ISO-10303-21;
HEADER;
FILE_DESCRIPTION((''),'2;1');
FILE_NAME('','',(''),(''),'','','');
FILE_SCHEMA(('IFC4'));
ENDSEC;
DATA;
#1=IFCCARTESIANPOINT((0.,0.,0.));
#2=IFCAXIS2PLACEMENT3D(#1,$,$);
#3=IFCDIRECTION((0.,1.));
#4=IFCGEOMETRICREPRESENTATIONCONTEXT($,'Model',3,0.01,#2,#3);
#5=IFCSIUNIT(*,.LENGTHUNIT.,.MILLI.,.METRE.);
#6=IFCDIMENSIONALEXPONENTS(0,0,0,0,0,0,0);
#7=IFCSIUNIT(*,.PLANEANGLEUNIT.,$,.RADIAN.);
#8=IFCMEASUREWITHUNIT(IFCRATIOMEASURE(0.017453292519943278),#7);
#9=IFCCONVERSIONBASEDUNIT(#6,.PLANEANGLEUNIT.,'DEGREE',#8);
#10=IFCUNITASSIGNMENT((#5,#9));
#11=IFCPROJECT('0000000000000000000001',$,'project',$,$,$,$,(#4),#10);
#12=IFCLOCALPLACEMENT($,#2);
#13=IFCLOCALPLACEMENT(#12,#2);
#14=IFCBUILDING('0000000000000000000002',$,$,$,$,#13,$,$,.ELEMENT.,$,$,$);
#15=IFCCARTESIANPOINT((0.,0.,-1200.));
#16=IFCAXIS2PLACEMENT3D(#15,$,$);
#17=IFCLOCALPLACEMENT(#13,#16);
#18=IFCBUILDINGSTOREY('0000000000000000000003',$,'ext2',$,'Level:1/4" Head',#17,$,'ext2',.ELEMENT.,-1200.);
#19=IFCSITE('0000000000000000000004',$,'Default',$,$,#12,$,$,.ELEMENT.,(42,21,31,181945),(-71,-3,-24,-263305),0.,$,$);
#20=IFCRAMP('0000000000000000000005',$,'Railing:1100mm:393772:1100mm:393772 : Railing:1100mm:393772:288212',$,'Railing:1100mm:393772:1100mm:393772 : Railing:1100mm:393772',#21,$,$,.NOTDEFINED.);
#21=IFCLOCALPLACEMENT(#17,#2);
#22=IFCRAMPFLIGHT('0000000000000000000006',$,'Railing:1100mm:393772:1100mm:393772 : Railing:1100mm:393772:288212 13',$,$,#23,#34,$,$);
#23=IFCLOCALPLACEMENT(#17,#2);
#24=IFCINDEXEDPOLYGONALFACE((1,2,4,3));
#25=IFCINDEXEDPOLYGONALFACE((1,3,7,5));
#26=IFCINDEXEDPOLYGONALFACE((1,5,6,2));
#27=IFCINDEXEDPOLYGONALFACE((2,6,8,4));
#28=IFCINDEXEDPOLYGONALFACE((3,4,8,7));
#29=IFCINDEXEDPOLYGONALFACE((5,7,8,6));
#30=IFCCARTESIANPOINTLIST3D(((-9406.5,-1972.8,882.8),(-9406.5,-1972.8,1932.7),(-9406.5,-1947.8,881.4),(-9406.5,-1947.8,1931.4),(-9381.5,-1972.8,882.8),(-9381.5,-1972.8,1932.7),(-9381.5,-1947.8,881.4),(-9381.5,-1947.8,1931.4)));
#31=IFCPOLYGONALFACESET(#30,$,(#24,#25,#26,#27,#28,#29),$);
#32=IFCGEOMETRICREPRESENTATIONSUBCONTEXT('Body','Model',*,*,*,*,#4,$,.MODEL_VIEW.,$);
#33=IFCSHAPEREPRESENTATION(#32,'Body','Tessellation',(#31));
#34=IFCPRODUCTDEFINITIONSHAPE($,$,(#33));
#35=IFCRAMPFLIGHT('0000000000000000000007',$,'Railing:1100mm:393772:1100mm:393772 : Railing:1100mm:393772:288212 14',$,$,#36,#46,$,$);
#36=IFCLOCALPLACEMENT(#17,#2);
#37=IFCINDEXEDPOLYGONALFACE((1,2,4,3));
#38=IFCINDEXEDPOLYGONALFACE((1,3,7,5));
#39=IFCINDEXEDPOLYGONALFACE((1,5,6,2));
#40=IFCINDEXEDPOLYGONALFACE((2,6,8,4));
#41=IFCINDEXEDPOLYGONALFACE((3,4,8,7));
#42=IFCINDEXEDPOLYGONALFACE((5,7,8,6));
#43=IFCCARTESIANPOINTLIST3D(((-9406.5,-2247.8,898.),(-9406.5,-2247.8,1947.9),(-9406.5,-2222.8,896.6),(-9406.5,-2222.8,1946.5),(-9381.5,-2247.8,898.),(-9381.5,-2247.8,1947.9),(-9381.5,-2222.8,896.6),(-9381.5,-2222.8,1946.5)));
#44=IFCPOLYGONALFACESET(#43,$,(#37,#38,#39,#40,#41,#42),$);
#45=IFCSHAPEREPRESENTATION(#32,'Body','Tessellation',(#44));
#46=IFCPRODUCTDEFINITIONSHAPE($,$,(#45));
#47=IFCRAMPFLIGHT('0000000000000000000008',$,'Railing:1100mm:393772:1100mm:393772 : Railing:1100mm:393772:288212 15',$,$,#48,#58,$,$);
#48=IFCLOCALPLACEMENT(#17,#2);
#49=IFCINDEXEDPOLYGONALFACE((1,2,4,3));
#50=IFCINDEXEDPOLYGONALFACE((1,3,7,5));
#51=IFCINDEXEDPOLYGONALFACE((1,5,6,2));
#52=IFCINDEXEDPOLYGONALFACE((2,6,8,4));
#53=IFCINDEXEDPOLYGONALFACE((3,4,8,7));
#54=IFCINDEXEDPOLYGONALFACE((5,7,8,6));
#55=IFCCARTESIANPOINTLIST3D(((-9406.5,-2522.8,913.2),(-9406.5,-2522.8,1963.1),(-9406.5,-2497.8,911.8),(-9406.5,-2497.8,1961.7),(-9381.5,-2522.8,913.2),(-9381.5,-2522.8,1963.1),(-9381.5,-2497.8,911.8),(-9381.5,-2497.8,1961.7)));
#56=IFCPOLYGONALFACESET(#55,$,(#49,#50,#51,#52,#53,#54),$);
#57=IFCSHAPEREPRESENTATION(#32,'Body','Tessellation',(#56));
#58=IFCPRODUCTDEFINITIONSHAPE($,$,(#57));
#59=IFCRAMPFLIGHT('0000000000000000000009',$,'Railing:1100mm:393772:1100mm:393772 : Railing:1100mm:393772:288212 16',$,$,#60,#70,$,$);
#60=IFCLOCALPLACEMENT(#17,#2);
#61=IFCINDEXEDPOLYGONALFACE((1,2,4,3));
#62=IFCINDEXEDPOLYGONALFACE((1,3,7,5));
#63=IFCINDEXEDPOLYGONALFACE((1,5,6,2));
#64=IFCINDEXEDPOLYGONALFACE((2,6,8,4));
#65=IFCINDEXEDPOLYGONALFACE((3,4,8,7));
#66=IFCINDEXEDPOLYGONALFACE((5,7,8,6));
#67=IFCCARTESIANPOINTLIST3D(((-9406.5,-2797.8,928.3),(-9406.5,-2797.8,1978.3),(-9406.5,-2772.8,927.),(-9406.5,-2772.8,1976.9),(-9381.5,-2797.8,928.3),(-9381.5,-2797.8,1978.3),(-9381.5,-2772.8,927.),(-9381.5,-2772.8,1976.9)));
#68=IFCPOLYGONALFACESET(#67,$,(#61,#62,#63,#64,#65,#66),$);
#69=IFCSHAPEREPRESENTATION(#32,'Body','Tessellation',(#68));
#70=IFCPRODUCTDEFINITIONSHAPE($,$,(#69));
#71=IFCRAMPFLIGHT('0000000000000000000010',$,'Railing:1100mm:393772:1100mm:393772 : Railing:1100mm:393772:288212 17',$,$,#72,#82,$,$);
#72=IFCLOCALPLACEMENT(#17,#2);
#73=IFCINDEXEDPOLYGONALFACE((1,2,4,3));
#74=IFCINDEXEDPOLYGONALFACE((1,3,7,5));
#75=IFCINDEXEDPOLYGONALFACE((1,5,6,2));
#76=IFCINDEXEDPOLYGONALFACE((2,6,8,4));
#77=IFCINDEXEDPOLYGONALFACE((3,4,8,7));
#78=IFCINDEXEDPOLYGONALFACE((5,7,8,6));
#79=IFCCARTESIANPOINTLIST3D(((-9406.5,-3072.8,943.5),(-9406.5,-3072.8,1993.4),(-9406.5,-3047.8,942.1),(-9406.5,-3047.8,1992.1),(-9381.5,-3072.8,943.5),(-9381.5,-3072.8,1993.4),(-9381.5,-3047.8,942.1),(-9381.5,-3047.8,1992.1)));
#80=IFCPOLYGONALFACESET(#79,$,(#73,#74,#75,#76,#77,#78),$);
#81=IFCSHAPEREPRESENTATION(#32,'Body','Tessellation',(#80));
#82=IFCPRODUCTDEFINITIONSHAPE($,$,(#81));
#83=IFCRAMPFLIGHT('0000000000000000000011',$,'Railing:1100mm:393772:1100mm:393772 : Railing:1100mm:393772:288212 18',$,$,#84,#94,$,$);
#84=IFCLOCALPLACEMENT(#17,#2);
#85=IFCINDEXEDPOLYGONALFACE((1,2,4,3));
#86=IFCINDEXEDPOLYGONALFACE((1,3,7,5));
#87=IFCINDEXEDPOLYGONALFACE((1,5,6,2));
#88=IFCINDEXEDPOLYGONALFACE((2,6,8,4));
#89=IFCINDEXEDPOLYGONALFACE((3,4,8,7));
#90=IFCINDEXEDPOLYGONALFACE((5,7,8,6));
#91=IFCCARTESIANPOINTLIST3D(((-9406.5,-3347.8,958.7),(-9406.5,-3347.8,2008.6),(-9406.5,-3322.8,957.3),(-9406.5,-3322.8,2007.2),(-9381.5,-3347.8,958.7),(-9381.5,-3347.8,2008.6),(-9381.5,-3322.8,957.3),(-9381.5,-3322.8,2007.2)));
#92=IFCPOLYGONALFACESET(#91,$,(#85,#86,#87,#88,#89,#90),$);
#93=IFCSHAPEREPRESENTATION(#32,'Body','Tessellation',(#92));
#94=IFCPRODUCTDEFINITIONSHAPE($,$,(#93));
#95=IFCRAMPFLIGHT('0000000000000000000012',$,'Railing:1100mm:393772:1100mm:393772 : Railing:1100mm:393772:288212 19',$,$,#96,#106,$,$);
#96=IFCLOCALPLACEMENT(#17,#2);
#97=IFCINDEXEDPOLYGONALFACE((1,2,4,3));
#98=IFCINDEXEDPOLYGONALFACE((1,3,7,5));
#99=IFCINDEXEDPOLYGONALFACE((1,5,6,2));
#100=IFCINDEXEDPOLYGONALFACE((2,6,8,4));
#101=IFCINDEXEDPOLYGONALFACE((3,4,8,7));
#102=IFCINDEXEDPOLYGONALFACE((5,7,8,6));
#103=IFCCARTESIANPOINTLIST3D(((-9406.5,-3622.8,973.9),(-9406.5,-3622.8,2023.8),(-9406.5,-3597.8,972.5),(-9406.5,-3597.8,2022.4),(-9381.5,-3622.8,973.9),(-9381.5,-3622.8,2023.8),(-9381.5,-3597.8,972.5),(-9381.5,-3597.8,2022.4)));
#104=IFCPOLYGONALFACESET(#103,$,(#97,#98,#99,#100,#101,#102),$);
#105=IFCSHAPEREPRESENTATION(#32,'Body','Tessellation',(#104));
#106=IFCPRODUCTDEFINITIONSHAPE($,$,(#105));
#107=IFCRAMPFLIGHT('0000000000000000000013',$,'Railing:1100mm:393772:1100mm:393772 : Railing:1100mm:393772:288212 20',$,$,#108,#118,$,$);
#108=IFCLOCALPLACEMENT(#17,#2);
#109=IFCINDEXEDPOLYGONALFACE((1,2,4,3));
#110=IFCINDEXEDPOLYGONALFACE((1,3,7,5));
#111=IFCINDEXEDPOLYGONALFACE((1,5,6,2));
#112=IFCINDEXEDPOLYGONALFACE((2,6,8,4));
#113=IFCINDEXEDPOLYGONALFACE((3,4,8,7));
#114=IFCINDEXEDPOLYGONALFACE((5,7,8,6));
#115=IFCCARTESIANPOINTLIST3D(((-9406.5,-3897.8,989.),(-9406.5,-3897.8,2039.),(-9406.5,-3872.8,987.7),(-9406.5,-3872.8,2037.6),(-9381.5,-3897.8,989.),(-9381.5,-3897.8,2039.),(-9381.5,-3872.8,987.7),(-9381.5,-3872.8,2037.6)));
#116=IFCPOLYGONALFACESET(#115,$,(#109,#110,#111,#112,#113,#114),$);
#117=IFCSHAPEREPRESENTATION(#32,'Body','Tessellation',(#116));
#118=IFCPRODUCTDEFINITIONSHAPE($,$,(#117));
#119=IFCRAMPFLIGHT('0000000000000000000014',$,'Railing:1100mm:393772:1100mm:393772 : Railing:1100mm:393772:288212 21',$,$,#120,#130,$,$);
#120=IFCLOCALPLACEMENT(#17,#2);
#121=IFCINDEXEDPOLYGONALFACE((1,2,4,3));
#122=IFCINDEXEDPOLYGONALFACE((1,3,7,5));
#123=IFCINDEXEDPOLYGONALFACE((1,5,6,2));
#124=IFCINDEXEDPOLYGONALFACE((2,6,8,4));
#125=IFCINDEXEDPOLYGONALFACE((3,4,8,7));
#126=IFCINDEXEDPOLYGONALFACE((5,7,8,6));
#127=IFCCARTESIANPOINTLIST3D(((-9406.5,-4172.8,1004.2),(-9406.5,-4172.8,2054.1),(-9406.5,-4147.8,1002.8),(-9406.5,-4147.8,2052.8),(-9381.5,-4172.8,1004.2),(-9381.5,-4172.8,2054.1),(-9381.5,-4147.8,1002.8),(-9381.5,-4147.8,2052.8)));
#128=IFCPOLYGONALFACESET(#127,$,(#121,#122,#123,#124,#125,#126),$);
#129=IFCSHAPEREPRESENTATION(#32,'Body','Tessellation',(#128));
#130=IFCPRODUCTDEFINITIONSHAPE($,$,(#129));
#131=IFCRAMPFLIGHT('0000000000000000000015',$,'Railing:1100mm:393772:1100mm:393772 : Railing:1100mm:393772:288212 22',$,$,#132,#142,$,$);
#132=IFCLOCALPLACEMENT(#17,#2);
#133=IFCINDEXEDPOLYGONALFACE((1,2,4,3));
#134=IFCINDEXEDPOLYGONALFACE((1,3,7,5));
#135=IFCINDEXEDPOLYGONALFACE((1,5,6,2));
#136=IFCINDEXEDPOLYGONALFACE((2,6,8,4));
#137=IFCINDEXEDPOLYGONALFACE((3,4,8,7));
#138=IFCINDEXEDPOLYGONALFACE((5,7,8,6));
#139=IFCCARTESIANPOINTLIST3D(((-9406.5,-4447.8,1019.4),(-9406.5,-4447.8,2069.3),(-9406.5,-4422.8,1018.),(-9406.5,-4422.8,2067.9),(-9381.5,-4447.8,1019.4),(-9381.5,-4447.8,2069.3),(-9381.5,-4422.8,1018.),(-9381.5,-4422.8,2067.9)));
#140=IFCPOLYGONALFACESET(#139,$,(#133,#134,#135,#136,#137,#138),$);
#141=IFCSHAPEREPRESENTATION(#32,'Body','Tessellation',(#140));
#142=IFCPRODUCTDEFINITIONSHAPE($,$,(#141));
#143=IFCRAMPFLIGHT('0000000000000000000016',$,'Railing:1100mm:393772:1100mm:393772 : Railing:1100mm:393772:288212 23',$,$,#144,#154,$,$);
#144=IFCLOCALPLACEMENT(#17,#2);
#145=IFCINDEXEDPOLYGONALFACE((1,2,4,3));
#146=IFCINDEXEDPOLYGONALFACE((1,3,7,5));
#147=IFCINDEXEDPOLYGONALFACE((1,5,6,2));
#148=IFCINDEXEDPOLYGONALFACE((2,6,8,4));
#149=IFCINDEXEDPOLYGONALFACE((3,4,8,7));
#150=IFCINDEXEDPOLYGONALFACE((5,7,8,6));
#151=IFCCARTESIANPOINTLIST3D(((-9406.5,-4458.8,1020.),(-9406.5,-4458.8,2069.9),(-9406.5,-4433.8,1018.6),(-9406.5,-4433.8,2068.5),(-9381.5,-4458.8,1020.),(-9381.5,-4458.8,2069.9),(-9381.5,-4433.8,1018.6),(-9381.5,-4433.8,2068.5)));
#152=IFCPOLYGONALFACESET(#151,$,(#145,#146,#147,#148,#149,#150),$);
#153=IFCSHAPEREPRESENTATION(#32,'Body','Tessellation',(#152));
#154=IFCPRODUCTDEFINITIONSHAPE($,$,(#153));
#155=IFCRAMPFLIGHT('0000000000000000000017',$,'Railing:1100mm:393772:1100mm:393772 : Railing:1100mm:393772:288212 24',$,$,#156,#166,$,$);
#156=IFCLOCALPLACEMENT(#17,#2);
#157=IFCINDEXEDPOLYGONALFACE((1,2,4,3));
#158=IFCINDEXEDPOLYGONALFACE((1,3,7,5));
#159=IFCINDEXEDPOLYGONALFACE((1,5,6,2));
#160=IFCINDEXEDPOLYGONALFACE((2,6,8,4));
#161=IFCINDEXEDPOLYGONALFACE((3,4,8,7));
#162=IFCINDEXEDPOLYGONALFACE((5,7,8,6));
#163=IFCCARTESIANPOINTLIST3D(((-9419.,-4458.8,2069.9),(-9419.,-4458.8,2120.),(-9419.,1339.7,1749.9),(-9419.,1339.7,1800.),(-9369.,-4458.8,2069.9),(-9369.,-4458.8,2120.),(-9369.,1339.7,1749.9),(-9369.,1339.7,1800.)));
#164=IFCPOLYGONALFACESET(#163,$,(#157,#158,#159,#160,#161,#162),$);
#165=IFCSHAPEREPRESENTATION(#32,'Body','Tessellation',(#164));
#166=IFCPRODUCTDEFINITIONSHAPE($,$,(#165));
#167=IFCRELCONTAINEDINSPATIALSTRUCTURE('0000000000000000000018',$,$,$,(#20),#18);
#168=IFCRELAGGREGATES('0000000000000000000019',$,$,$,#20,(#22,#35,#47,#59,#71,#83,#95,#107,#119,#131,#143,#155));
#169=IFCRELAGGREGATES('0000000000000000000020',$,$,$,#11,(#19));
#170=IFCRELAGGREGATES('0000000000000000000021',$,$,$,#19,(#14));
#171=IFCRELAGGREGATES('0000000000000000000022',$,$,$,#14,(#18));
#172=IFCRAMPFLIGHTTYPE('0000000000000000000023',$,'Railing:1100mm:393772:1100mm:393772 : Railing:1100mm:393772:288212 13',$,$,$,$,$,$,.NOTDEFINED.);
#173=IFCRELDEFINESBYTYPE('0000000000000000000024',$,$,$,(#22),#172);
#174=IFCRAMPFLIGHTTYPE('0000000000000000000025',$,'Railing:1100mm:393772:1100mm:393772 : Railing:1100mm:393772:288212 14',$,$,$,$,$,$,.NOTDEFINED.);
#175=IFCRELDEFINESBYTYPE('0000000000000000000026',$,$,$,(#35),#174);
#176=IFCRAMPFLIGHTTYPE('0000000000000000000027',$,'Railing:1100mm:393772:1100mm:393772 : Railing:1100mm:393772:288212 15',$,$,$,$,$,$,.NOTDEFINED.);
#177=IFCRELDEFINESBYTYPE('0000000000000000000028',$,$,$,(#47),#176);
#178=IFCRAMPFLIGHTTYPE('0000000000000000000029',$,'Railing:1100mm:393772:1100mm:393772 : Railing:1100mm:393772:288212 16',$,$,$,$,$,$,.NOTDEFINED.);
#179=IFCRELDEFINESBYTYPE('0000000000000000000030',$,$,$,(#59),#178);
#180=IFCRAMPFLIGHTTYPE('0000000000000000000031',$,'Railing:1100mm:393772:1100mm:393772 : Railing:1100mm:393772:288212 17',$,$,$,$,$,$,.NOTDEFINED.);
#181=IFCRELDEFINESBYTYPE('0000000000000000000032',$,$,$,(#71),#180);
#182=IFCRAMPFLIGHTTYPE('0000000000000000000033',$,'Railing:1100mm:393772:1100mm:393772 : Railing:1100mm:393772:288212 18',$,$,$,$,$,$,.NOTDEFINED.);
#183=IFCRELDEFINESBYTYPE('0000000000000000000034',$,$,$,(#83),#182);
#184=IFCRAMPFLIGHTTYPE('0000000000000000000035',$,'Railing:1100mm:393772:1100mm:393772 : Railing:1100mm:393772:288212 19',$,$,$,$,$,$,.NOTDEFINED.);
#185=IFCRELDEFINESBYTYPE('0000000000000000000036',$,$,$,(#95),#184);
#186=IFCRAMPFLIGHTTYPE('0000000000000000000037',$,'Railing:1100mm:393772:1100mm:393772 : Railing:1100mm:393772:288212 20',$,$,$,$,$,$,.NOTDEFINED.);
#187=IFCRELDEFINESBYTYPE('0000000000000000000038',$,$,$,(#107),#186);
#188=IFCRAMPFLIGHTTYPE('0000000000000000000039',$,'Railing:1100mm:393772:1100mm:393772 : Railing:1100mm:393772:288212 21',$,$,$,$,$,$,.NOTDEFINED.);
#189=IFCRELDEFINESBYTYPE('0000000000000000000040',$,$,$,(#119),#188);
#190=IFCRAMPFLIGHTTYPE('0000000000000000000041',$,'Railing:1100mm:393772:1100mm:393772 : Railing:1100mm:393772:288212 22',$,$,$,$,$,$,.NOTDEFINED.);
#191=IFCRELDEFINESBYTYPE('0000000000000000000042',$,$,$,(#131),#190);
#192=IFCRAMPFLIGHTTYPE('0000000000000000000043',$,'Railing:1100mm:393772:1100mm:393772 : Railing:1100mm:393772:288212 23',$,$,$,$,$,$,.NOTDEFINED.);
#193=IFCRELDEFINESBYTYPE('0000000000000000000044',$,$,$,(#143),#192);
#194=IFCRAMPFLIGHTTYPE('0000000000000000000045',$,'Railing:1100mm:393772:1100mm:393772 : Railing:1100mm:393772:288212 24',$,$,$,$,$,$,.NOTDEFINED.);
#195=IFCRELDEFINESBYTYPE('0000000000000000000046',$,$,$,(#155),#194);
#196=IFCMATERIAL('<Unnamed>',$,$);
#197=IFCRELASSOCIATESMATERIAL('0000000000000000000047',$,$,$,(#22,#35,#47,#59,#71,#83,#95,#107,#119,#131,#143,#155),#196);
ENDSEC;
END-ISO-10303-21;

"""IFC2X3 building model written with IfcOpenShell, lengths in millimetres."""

from ifc_helpers import new_model, entity, si_unit, converted_unit, direction, frame, origin, place, context, subcontext, project, spatial, polyline, outline, extrude, material, type_object, element, aggregate, save


model = new_model("IFC2X3")

# Units and contexts
model_context = context("Model", 3, precision=0.01, world=origin(), true_north=direction((0.0, 1.0)))
body_context = subcontext(model_context, "Body", "Model", "MODEL_VIEW")
ifc_project = project(units=[si_unit("LENGTHUNIT", "METRE", prefix="MILLI"), converted_unit("PLANEANGLEUNIT", "DEGREE", entity("IfcRatioMeasure", 0.017453292519943278), si_unit("PLANEANGLEUNIT", "RADIAN"), dimensions=[0, 0, 0, 0, 0, 0, 0])], contexts=[model_context])

# Site, building, storey
site_placement = place(None, origin())
site = spatial("IfcSite", under=ifc_project, at=site_placement, Name="Default", CompositionType="ELEMENT", RefLatitude=(42, 21, 31, 181945), RefLongitude=(-71, -3, -24, -263305), RefElevation=0.0)
building_placement = place(site_placement, origin())
building = spatial("IfcBuilding", under=site, at=building_placement, CompositionType="ELEMENT")
storey_placement = place(building_placement, frame((0.0, 0.0, -1200.0)))
storey = spatial("IfcBuildingStorey", under=building, at=storey_placement, Name="ext2", ObjectType="Level:1/4\" Head", LongName="ext2", CompositionType="ELEMENT", Elevation=-1200.0)

# Ramp, ramp flights
ramp_placement = place(storey_placement, origin())
ramp = element("IfcRamp", 1, at=ramp_placement, inside=storey, Name="Railing:1100mm:393772:1100mm:393772 : Railing:1100mm:393772:288212", ObjectType="Railing:1100mm:393772:1100mm:393772 : Railing:1100mm:393772", ShapeType="NOTDEFINED")
ifc_material = material(Name="<Unnamed>")
ramp_flight_type_1 = type_object("IfcRampFlightType", Name="Railing:1100mm:393772:1100mm:393772 : Railing:1100mm:393772:288212 13", PredefinedType="NOTDEFINED")
ramp_flight_1_placement = place(ramp_placement, origin())
ramp_flight_1 = element("IfcRampFlight", 2, at=ramp_flight_1_placement, type_object=ramp_flight_type_1, material=ifc_material, Name="Railing:1100mm:393772:1100mm:393772 : Railing:1100mm:393772:288212 13", context=body_context, shape_type="SweptSolid", body=[
    extrude(outline(polyline([(-525.7, -12.5), (524.3, -12.5), (525.7, 12.5), (-524.3, 12.5), (-525.7, -12.5)])), frame((-9406.5, -1960.3, 1407.1), z_axis=(1.0, 0.0, 0.0), x_axis=(0.0, 0.0, -1.0)), (0.0, 0.0, 1.0), 25.0),
])
ramp_flight_type_2 = type_object("IfcRampFlightType", Name="Railing:1100mm:393772:1100mm:393772 : Railing:1100mm:393772:288212 14", PredefinedType="NOTDEFINED")
ramp_flight_2_placement = place(ramp_placement, origin())
ramp_flight_2 = element("IfcRampFlight", 3, at=ramp_flight_2_placement, type_object=ramp_flight_type_2, material=ifc_material, Name="Railing:1100mm:393772:1100mm:393772 : Railing:1100mm:393772:288212 14", context=body_context, shape_type="SweptSolid", body=[
    extrude(outline(polyline([(-525.7, -12.5), (524.3, -12.5), (525.7, 12.5), (-524.3, 12.5), (-525.7, -12.5)])), frame((-9406.5, -2235.3, 1422.3), z_axis=(1.0, 0.0, 0.0), x_axis=(0.0, 0.0, -1.0)), (0.0, 0.0, 1.0), 25.0),
])
ramp_flight_type_3 = type_object("IfcRampFlightType", Name="Railing:1100mm:393772:1100mm:393772 : Railing:1100mm:393772:288212 15", PredefinedType="NOTDEFINED")
ramp_flight_3_placement = place(ramp_placement, origin())
ramp_flight_3 = element("IfcRampFlight", 4, at=ramp_flight_3_placement, type_object=ramp_flight_type_3, material=ifc_material, Name="Railing:1100mm:393772:1100mm:393772 : Railing:1100mm:393772:288212 15", context=body_context, shape_type="SweptSolid", body=[
    extrude(outline(polyline([(-525.7, -12.5), (524.3, -12.5), (525.7, 12.5), (-524.3, 12.5), (-525.7, -12.5)])), frame((-9406.5, -2510.3, 1437.4), z_axis=(1.0, 0.0, 0.0), x_axis=(0.0, 0.0, -1.0)), (0.0, 0.0, 1.0), 25.0),
])
ramp_flight_type_4 = type_object("IfcRampFlightType", Name="Railing:1100mm:393772:1100mm:393772 : Railing:1100mm:393772:288212 16", PredefinedType="NOTDEFINED")
ramp_flight_4_placement = place(ramp_placement, origin())
ramp_flight_4 = element("IfcRampFlight", 5, at=ramp_flight_4_placement, type_object=ramp_flight_type_4, material=ifc_material, Name="Railing:1100mm:393772:1100mm:393772 : Railing:1100mm:393772:288212 16", context=body_context, shape_type="SweptSolid", body=[
    extrude(outline(polyline([(-525.7, -12.5), (524.3, -12.5), (525.7, 12.5), (-524.3, 12.5), (-525.7, -12.5)])), frame((-9406.5, -2785.3, 1452.6), z_axis=(1.0, 0.0, 0.0), x_axis=(0.0, 0.0, -1.0)), (0.0, 0.0, 1.0), 25.0),
])
ramp_flight_type_5 = type_object("IfcRampFlightType", Name="Railing:1100mm:393772:1100mm:393772 : Railing:1100mm:393772:288212 17", PredefinedType="NOTDEFINED")
ramp_flight_5_placement = place(ramp_placement, origin())
ramp_flight_5 = element("IfcRampFlight", 6, at=ramp_flight_5_placement, type_object=ramp_flight_type_5, material=ifc_material, Name="Railing:1100mm:393772:1100mm:393772 : Railing:1100mm:393772:288212 17", context=body_context, shape_type="SweptSolid", body=[
    extrude(outline(polyline([(-525.7, -12.5), (524.3, -12.5), (525.7, 12.5), (-524.3, 12.5), (-525.7, -12.5)])), frame((-9406.5, -3060.3, 1467.8), z_axis=(1.0, 0.0, 0.0), x_axis=(0.0, 0.0, -1.0)), (0.0, 0.0, 1.0), 25.0),
])
ramp_flight_type_6 = type_object("IfcRampFlightType", Name="Railing:1100mm:393772:1100mm:393772 : Railing:1100mm:393772:288212 18", PredefinedType="NOTDEFINED")
ramp_flight_6_placement = place(ramp_placement, origin())
ramp_flight_6 = element("IfcRampFlight", 7, at=ramp_flight_6_placement, type_object=ramp_flight_type_6, material=ifc_material, Name="Railing:1100mm:393772:1100mm:393772 : Railing:1100mm:393772:288212 18", context=body_context, shape_type="SweptSolid", body=[
    extrude(outline(polyline([(-525.7, -12.5), (524.3, -12.5), (525.7, 12.5), (-524.3, 12.5), (-525.7, -12.5)])), frame((-9406.5, -3335.3, 1483.0), z_axis=(1.0, 0.0, 0.0), x_axis=(0.0, 0.0, -1.0)), (0.0, 0.0, 1.0), 25.0),
])
ramp_flight_type_7 = type_object("IfcRampFlightType", Name="Railing:1100mm:393772:1100mm:393772 : Railing:1100mm:393772:288212 19", PredefinedType="NOTDEFINED")
ramp_flight_7_placement = place(ramp_placement, origin())
ramp_flight_7 = element("IfcRampFlight", 8, at=ramp_flight_7_placement, type_object=ramp_flight_type_7, material=ifc_material, Name="Railing:1100mm:393772:1100mm:393772 : Railing:1100mm:393772:288212 19", context=body_context, shape_type="SweptSolid", body=[
    extrude(outline(polyline([(-525.7, -12.5), (524.3, -12.5), (525.7, 12.5), (-524.3, 12.5), (-525.7, -12.5)])), frame((-9406.5, -3610.3, 1498.1), z_axis=(1.0, 0.0, 0.0), x_axis=(0.0, 0.0, -1.0)), (0.0, 0.0, 1.0), 25.0),
])
ramp_flight_type_8 = type_object("IfcRampFlightType", Name="Railing:1100mm:393772:1100mm:393772 : Railing:1100mm:393772:288212 20", PredefinedType="NOTDEFINED")
ramp_flight_8_placement = place(ramp_placement, origin())
ramp_flight_8 = element("IfcRampFlight", 9, at=ramp_flight_8_placement, type_object=ramp_flight_type_8, material=ifc_material, Name="Railing:1100mm:393772:1100mm:393772 : Railing:1100mm:393772:288212 20", context=body_context, shape_type="SweptSolid", body=[
    extrude(outline(polyline([(-525.7, -12.5), (524.3, -12.5), (525.7, 12.5), (-524.3, 12.5), (-525.7, -12.5)])), frame((-9406.5, -3885.3, 1513.3), z_axis=(1.0, 0.0, 0.0), x_axis=(0.0, 0.0, -1.0)), (0.0, 0.0, 1.0), 25.0),
])
ramp_flight_type_9 = type_object("IfcRampFlightType", Name="Railing:1100mm:393772:1100mm:393772 : Railing:1100mm:393772:288212 21", PredefinedType="NOTDEFINED")
ramp_flight_9_placement = place(ramp_placement, origin())
ramp_flight_9 = element("IfcRampFlight", 10, at=ramp_flight_9_placement, type_object=ramp_flight_type_9, material=ifc_material, Name="Railing:1100mm:393772:1100mm:393772 : Railing:1100mm:393772:288212 21", context=body_context, shape_type="SweptSolid", body=[
    extrude(outline(polyline([(-525.7, -12.5), (524.3, -12.5), (525.7, 12.5), (-524.3, 12.5), (-525.7, -12.5)])), frame((-9406.5, -4160.3, 1528.5), z_axis=(1.0, 0.0, 0.0), x_axis=(0.0, 0.0, -1.0)), (0.0, 0.0, 1.0), 25.0),
])
ramp_flight_type_10 = type_object("IfcRampFlightType", Name="Railing:1100mm:393772:1100mm:393772 : Railing:1100mm:393772:288212 22", PredefinedType="NOTDEFINED")
ramp_flight_10_placement = place(ramp_placement, origin())
ramp_flight_10 = element("IfcRampFlight", 11, at=ramp_flight_10_placement, type_object=ramp_flight_type_10, material=ifc_material, Name="Railing:1100mm:393772:1100mm:393772 : Railing:1100mm:393772:288212 22", context=body_context, shape_type="SweptSolid", body=[
    extrude(outline(polyline([(-525.7, -12.5), (524.3, -12.5), (525.7, 12.5), (-524.3, 12.5), (-525.7, -12.5)])), frame((-9406.5, -4435.3, 1543.7), z_axis=(1.0, 0.0, 0.0), x_axis=(0.0, 0.0, -1.0)), (0.0, 0.0, 1.0), 25.0),
])
ramp_flight_type_11 = type_object("IfcRampFlightType", Name="Railing:1100mm:393772:1100mm:393772 : Railing:1100mm:393772:288212 23", PredefinedType="NOTDEFINED")
ramp_flight_11_placement = place(ramp_placement, origin())
ramp_flight_11 = element("IfcRampFlight", 12, at=ramp_flight_11_placement, type_object=ramp_flight_type_11, material=ifc_material, Name="Railing:1100mm:393772:1100mm:393772 : Railing:1100mm:393772:288212 23", context=body_context, shape_type="SweptSolid", body=[
    extrude(outline(polyline([(-525.7, -12.5), (524.3, -12.5), (525.7, 12.5), (-524.3, 12.5), (-525.7, -12.5)])), frame((-9406.5, -4446.3, 1544.3), z_axis=(1.0, 0.0, 0.0), x_axis=(0.0, 0.0, -1.0)), (0.0, 0.0, 1.0), 25.0),
])
ramp_flight_type_12 = type_object("IfcRampFlightType", Name="Railing:1100mm:393772:1100mm:393772 : Railing:1100mm:393772:288212 24", PredefinedType="NOTDEFINED")
ramp_flight_12_placement = place(ramp_placement, origin())
ramp_flight_12 = element("IfcRampFlight", 13, at=ramp_flight_12_placement, type_object=ramp_flight_type_12, material=ifc_material, Name="Railing:1100mm:393772:1100mm:393772 : Railing:1100mm:393772:288212 24", context=body_context, shape_type="SweptSolid", body=[
    extrude(outline(polyline([(-185.0, -2899.2), (-135.0, -2899.2), (185.0, 2899.2), (135.0, 2899.2), (-185.0, -2899.2)])), frame((-9419.0, -1559.5, 1935.0), z_axis=(1.0, 0.0, 0.0), x_axis=(0.0, 0.0, -1.0)), (0.0, 0.0, 1.0), 50.0),
])
aggregate(ramp, [ramp_flight_1, ramp_flight_2, ramp_flight_3, ramp_flight_4, ramp_flight_5, ramp_flight_6, ramp_flight_7, ramp_flight_8, ramp_flight_9, ramp_flight_10, ramp_flight_11, ramp_flight_12])

save(model, "model.ifc")
